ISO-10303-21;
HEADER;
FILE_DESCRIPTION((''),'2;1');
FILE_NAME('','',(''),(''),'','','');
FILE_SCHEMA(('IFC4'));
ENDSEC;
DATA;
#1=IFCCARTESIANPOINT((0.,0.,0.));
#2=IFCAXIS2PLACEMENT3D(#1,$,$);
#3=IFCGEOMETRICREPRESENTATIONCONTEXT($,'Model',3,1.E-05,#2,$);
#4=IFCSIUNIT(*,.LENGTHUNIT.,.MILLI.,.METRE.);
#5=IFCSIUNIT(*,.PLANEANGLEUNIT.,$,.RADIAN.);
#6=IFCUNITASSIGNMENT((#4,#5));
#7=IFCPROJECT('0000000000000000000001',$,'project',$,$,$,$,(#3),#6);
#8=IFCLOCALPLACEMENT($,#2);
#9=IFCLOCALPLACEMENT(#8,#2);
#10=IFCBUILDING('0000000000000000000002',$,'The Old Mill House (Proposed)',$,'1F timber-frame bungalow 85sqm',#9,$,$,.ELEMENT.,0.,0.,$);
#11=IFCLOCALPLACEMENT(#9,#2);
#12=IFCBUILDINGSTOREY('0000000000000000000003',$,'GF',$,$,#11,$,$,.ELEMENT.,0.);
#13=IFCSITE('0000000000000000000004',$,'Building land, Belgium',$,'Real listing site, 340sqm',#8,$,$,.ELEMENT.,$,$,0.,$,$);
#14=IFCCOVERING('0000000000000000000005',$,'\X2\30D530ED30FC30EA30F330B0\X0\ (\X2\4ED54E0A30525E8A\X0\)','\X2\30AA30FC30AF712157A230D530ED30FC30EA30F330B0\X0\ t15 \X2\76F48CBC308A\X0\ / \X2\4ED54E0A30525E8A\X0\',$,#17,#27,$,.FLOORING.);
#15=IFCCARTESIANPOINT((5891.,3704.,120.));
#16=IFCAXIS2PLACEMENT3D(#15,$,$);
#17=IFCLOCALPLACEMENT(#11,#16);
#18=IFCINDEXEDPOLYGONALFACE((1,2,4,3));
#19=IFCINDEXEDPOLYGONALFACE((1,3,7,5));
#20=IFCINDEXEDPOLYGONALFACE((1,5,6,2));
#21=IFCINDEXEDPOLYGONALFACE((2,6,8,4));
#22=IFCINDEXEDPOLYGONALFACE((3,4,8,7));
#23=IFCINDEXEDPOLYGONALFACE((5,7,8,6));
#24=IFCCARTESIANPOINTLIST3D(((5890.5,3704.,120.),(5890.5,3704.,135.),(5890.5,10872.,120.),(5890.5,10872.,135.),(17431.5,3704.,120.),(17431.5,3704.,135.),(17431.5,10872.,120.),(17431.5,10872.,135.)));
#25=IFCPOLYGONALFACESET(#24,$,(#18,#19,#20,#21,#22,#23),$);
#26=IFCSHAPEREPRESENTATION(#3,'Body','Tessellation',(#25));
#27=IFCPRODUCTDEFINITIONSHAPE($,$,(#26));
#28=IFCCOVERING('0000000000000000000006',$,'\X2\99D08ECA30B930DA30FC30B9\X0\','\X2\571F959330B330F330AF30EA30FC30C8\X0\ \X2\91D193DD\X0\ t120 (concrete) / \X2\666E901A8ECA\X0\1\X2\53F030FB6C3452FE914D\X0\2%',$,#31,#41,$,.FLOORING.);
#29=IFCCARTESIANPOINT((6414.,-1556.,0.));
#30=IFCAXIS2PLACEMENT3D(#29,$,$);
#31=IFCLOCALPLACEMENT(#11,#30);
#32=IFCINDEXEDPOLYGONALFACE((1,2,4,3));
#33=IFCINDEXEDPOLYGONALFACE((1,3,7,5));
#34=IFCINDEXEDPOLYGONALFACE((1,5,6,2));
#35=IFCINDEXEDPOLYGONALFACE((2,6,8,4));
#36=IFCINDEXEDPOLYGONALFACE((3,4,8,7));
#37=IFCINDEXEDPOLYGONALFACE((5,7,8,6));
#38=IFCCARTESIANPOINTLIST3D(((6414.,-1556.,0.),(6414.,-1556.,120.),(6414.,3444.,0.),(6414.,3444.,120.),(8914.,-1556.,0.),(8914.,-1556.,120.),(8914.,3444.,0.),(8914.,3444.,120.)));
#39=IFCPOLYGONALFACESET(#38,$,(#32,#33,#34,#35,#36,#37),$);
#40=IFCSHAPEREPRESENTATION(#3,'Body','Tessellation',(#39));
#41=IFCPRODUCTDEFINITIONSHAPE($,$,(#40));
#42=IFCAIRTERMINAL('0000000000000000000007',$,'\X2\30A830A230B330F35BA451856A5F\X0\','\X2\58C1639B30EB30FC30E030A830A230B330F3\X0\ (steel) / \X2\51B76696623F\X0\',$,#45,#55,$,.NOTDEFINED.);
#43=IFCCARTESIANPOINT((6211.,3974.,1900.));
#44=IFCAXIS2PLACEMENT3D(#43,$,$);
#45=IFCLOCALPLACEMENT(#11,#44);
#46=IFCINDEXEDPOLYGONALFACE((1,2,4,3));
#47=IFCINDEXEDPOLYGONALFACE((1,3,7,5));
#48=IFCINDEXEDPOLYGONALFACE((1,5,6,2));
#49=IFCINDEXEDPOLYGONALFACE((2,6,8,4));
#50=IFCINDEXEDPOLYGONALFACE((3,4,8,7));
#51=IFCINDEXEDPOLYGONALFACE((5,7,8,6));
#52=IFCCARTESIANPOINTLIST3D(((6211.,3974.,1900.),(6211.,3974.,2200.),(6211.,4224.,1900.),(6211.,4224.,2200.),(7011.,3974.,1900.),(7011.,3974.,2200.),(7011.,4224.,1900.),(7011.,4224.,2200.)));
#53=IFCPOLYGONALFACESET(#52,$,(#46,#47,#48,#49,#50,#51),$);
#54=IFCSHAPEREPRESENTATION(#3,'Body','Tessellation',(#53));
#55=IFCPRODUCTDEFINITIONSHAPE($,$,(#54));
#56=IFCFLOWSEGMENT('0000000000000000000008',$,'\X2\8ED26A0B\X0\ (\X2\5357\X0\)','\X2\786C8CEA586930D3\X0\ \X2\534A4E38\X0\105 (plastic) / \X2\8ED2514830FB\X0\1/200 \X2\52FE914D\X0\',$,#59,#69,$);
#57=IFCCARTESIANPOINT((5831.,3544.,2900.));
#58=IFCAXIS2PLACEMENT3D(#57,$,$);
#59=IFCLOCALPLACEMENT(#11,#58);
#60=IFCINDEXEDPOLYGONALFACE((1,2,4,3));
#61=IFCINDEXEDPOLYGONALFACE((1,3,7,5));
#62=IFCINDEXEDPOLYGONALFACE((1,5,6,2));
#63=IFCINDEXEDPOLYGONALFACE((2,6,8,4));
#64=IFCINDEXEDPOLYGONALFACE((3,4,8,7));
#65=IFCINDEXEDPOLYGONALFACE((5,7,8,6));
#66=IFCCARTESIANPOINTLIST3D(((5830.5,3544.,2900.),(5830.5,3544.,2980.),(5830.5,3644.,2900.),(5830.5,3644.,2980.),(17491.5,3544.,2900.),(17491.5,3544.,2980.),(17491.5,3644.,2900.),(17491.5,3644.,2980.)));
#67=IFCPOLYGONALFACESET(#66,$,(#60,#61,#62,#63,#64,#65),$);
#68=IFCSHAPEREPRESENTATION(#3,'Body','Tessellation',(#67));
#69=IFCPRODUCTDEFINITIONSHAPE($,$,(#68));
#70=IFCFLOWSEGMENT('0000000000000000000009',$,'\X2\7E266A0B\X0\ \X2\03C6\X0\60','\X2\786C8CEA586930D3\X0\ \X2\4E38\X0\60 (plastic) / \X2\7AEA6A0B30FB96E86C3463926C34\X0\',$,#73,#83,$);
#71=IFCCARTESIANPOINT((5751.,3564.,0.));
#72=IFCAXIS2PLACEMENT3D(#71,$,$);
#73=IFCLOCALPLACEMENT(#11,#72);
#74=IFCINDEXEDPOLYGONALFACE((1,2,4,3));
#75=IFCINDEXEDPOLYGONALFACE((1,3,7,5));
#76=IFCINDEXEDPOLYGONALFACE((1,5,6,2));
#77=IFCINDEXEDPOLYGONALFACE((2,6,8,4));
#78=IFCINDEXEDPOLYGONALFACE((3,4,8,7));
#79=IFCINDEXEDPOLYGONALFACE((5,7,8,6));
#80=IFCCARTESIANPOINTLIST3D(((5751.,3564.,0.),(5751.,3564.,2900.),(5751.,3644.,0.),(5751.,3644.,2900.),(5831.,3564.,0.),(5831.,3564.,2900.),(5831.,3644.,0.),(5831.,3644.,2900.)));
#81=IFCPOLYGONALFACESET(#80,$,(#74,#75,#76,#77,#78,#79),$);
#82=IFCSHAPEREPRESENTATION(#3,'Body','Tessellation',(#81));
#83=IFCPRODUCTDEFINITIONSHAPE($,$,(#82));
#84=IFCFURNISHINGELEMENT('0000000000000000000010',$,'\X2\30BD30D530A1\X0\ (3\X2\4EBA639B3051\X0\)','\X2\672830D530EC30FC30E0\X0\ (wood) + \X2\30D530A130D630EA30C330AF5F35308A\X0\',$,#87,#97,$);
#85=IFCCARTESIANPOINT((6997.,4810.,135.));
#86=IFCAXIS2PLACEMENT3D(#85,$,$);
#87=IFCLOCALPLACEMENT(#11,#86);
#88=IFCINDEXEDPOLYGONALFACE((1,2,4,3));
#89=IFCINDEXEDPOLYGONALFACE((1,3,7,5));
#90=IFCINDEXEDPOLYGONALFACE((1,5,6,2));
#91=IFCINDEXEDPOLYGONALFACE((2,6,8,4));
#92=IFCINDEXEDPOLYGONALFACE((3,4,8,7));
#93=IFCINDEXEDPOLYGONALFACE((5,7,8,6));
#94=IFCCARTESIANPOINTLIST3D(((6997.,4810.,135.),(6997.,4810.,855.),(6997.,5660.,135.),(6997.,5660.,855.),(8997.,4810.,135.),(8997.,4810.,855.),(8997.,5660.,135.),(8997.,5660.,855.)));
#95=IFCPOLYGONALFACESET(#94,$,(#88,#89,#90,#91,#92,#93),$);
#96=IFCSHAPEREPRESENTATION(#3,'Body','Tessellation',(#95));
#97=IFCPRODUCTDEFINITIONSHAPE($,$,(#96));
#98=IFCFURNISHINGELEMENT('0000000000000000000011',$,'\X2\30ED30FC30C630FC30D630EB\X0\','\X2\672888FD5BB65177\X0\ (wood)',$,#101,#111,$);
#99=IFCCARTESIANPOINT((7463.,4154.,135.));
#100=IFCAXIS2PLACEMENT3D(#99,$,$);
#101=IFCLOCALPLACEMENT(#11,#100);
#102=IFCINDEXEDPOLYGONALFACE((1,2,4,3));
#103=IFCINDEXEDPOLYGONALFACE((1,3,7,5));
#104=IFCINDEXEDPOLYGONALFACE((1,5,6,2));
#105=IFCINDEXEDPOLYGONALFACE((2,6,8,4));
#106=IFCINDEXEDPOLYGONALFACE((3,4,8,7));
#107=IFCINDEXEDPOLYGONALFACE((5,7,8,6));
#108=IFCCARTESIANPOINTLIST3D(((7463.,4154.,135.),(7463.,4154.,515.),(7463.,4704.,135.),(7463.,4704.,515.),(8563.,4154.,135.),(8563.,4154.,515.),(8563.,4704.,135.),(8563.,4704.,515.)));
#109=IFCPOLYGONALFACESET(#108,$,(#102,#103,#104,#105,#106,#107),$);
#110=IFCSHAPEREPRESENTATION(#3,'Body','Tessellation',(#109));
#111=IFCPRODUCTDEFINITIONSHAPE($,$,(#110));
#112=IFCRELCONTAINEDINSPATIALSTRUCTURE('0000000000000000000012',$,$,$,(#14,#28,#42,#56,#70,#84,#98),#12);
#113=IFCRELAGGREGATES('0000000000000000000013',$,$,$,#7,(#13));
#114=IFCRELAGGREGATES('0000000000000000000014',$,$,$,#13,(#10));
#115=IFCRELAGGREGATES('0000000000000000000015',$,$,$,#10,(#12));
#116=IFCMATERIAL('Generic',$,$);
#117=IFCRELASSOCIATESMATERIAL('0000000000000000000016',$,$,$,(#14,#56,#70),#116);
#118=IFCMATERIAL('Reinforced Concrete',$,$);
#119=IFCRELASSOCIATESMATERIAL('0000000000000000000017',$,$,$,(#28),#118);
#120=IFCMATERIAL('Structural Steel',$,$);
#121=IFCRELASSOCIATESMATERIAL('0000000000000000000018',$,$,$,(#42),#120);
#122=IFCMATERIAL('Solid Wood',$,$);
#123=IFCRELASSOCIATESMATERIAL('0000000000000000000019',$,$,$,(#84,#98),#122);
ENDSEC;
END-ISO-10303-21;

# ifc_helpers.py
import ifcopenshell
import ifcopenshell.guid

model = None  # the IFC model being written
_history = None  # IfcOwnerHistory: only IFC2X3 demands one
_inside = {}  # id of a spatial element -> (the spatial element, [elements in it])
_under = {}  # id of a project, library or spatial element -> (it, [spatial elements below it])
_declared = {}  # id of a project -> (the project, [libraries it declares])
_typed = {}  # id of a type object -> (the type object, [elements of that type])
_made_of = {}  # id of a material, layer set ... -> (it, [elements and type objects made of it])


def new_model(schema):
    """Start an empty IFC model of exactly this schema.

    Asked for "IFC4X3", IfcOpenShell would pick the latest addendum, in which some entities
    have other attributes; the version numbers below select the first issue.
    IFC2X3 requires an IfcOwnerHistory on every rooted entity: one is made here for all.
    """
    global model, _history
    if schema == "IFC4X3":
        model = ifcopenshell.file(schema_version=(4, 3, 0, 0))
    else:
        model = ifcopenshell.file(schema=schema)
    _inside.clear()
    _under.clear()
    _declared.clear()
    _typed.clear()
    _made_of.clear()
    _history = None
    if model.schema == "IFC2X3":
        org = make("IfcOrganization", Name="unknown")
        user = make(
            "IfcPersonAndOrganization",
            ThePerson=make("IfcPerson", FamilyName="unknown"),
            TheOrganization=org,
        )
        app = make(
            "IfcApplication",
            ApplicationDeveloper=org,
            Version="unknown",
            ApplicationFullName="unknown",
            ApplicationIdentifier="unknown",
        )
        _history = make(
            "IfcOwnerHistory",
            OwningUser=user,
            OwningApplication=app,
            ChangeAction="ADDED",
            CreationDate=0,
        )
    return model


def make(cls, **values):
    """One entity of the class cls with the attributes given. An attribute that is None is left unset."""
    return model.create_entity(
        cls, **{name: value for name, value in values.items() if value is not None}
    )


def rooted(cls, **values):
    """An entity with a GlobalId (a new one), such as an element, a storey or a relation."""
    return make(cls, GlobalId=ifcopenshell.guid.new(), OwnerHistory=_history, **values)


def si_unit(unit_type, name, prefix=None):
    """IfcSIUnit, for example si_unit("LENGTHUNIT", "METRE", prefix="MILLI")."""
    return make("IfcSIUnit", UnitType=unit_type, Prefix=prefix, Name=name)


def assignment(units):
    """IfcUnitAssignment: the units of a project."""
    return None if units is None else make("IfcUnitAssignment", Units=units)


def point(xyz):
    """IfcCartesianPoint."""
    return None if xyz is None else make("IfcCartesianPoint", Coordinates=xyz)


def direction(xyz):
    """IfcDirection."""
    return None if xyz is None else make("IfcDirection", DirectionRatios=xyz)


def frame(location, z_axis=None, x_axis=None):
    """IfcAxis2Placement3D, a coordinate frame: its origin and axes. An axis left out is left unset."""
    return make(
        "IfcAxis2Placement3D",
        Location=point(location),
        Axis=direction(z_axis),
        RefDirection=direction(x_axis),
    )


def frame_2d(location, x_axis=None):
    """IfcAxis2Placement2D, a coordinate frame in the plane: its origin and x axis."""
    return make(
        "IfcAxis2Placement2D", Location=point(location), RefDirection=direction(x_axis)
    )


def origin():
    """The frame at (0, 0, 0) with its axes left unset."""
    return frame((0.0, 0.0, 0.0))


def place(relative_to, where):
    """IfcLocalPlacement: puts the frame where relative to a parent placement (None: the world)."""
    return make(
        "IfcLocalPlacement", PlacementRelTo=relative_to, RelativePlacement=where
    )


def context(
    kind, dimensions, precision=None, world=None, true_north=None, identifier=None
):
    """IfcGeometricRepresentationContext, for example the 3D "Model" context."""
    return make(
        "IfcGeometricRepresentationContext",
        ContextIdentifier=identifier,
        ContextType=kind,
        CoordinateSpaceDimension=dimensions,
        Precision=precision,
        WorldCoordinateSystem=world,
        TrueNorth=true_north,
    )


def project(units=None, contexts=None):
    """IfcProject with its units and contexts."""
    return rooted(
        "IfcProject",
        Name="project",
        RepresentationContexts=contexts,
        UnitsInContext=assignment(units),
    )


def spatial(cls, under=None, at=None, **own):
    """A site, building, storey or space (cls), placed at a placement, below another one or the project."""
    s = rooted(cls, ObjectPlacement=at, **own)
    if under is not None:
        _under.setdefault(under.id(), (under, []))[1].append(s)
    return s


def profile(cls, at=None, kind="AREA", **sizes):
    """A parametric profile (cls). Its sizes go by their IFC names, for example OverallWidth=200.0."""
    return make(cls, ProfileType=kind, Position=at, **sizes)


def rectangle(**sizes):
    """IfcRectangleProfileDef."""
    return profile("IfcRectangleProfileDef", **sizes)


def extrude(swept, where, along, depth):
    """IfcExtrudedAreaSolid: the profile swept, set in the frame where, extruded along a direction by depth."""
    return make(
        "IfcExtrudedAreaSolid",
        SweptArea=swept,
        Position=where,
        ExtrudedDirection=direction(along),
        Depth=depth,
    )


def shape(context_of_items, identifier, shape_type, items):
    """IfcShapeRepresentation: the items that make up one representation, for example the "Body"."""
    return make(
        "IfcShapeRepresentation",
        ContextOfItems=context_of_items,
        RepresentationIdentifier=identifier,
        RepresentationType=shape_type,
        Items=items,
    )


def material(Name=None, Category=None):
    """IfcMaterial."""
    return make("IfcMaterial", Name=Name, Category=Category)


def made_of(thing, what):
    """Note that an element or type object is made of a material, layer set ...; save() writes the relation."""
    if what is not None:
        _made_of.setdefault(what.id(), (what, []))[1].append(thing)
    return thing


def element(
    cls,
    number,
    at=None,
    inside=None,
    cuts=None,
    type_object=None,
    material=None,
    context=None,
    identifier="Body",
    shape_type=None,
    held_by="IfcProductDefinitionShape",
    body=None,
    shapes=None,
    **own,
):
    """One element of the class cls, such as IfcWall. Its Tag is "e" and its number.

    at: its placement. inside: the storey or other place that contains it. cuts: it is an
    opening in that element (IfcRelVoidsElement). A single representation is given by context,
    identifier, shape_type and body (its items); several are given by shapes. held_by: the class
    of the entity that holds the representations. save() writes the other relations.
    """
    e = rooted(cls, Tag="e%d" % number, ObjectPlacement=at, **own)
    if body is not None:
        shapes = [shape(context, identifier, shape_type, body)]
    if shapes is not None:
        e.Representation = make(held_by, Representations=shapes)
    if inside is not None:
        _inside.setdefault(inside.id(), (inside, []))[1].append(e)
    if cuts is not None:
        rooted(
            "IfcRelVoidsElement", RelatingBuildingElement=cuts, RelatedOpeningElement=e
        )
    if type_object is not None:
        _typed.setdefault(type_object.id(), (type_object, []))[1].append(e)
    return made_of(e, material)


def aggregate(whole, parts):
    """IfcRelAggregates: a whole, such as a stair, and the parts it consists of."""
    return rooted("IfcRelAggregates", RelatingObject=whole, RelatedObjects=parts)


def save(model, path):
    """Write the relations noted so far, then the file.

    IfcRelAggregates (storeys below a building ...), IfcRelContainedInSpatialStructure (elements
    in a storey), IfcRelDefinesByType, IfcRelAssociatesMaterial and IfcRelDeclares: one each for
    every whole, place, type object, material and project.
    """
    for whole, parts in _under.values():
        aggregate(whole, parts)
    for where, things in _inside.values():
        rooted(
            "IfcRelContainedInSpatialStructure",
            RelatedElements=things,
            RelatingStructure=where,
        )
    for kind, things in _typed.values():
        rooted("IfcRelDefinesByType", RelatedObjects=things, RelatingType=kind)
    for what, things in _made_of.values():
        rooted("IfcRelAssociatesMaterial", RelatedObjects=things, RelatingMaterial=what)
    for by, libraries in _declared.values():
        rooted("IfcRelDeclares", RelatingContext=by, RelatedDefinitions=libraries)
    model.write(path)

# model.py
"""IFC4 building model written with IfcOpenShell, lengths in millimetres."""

from ifc_helpers import new_model, si_unit, frame, frame_2d, origin, place, context, project, spatial, rectangle, extrude, material, element, save


model = new_model("IFC4")

# Units and contexts
model_context = context("Model", 3, precision=1e-05, world=origin())
ifc_project = project(units=[si_unit("LENGTHUNIT", "METRE", prefix="MILLI"), si_unit("PLANEANGLEUNIT", "RADIAN")], contexts=[model_context])

# Site, building, storey
site_placement = place(None, origin())
site = spatial("IfcSite", under=ifc_project, at=site_placement, Name="Building land, Belgium", ObjectType="Real listing site, 340sqm", CompositionType="ELEMENT", RefElevation=0.0)
building_placement = place(site_placement, origin())
building = spatial("IfcBuilding", under=site, at=building_placement, Name="The Old Mill House (Proposed)", ObjectType="1F timber-frame bungalow 85sqm", CompositionType="ELEMENT", ElevationOfRefHeight=0.0, ElevationOfTerrain=0.0)
storey_placement = place(building_placement, origin())
storey = spatial("IfcBuildingStorey", under=building, at=storey_placement, Name="GF", CompositionType="ELEMENT", Elevation=0.0)

# Shared definitions
ifc_material_1 = material(Name="Solid Wood")

# Shared definitions
ifc_material_2 = material(Name="Reinforced Concrete")

# Shared definitions
ifc_material_3 = material(Name="Structural Steel")

# Coverings
ifc_material_4 = material(Name="Generic")
covering_1_placement = place(storey_placement, frame((5891.0, 3704.0, 120.0)))
element("IfcCovering", 1, at=covering_1_placement, inside=storey, material=ifc_material_4, Name="フローリング (仕上げ床)", Description="オーク無垢フローリング t15 直貼り / 仕上げ床", PredefinedType="FLOORING", context=model_context, shape_type="SweptSolid", body=[
    extrude(rectangle(XDim=11541.0, YDim=7168.0, at=frame_2d((5770.0, 3584.0))), frame((5891.0, 3704.0, 120.0)), (0.0, 0.0, 1.0), 15.0),
])
covering_2_placement = place(storey_placement, frame((6414.0, -1556.0, 0.0)))
element("IfcCovering", 2, at=covering_2_placement, inside=storey, material=ifc_material_2, Name="駐車スペース", Description="土間コンクリート 金鏝 t120 (concrete) / 普通車1台・水勾配2%", PredefinedType="FLOORING", context=model_context, shape_type="SweptSolid", body=[
    extrude(rectangle(XDim=2500.0, YDim=5000.0, at=frame_2d((1250.0, 2500.0))), frame((6414.0, -1556.0, 0.0)), (0.0, 0.0, 1.0), 120.0),
])

# Air terminal
air_terminal_placement = place(storey_placement, frame((6211.0, 3974.0, 1900.0)))
element("IfcAirTerminal", 3, at=air_terminal_placement, inside=storey, material=ifc_material_3, Name="エアコン室内機", Description="壁掛ルームエアコン (steel) / 冷暖房", PredefinedType="NOTDEFINED", context=model_context, shape_type="SweptSolid", body=[
    extrude(rectangle(XDim=800.0, YDim=250.0, at=frame_2d((400.0, 125.0))), frame((6211.0, 3974.0, 1900.0)), (0.0, 0.0, 1.0), 300.0),
])

# Flow segments
flow_segment_1_placement = place(storey_placement, frame((5831.0, 3544.0, 2900.0)))
element("IfcFlowSegment", 4, at=flow_segment_1_placement, inside=storey, material=ifc_material_4, Name="軒樋 (南)", Description="硬質塩ビ 半丸105 (plastic) / 軒先・1/200 勾配", context=model_context, shape_type="SweptSolid", body=[
    extrude(rectangle(XDim=11661.0, YDim=100.0, at=frame_2d((5830.0, 50.0))), frame((5831.0, 3544.0, 2900.0)), (0.0, 0.0, 1.0), 80.0),
])
flow_segment_2_placement = place(storey_placement, frame((5751.0, 3564.0, 0.0)))
element("IfcFlowSegment", 5, at=flow_segment_2_placement, inside=storey, material=ifc_material_4, Name="縦樋 φ60", Description="硬質塩ビ 丸60 (plastic) / 竪樋・雨水排水", context=model_context, shape_type="SweptSolid", body=[
    extrude(rectangle(XDim=80.0, YDim=80.0, at=frame_2d((40.0, 40.0))), frame((5751.0, 3564.0, 0.0)), (0.0, 0.0, 1.0), 2900.0),
])

# Furnishing elements
furnishing_1_placement = place(storey_placement, frame((6997.0, 4810.0, 135.0)))
element("IfcFurnishingElement", 6, at=furnishing_1_placement, inside=storey, material=ifc_material_1, Name="ソファ (3人掛け)", Description="木フレーム (wood) + ファブリック張り", context=model_context, shape_type="SweptSolid", body=[
    extrude(rectangle(XDim=2000.0, YDim=850.0, at=frame_2d((1000.0, 425.0))), frame((6997.0, 4810.0, 135.0)), (0.0, 0.0, 1.0), 720.0),
])
furnishing_2_placement = place(storey_placement, frame((7463.0, 4154.0, 135.0)))
element("IfcFurnishingElement", 7, at=furnishing_2_placement, inside=storey, material=ifc_material_1, Name="ローテーブル", Description="木製家具 (wood)", context=model_context, shape_type="SweptSolid", body=[
    extrude(rectangle(XDim=1100.0, YDim=550.0, at=frame_2d((550.0, 275.0))), frame((7463.0, 4154.0, 135.0)), (0.0, 0.0, 1.0), 380.0),
])

save(model, "model.ifc")
